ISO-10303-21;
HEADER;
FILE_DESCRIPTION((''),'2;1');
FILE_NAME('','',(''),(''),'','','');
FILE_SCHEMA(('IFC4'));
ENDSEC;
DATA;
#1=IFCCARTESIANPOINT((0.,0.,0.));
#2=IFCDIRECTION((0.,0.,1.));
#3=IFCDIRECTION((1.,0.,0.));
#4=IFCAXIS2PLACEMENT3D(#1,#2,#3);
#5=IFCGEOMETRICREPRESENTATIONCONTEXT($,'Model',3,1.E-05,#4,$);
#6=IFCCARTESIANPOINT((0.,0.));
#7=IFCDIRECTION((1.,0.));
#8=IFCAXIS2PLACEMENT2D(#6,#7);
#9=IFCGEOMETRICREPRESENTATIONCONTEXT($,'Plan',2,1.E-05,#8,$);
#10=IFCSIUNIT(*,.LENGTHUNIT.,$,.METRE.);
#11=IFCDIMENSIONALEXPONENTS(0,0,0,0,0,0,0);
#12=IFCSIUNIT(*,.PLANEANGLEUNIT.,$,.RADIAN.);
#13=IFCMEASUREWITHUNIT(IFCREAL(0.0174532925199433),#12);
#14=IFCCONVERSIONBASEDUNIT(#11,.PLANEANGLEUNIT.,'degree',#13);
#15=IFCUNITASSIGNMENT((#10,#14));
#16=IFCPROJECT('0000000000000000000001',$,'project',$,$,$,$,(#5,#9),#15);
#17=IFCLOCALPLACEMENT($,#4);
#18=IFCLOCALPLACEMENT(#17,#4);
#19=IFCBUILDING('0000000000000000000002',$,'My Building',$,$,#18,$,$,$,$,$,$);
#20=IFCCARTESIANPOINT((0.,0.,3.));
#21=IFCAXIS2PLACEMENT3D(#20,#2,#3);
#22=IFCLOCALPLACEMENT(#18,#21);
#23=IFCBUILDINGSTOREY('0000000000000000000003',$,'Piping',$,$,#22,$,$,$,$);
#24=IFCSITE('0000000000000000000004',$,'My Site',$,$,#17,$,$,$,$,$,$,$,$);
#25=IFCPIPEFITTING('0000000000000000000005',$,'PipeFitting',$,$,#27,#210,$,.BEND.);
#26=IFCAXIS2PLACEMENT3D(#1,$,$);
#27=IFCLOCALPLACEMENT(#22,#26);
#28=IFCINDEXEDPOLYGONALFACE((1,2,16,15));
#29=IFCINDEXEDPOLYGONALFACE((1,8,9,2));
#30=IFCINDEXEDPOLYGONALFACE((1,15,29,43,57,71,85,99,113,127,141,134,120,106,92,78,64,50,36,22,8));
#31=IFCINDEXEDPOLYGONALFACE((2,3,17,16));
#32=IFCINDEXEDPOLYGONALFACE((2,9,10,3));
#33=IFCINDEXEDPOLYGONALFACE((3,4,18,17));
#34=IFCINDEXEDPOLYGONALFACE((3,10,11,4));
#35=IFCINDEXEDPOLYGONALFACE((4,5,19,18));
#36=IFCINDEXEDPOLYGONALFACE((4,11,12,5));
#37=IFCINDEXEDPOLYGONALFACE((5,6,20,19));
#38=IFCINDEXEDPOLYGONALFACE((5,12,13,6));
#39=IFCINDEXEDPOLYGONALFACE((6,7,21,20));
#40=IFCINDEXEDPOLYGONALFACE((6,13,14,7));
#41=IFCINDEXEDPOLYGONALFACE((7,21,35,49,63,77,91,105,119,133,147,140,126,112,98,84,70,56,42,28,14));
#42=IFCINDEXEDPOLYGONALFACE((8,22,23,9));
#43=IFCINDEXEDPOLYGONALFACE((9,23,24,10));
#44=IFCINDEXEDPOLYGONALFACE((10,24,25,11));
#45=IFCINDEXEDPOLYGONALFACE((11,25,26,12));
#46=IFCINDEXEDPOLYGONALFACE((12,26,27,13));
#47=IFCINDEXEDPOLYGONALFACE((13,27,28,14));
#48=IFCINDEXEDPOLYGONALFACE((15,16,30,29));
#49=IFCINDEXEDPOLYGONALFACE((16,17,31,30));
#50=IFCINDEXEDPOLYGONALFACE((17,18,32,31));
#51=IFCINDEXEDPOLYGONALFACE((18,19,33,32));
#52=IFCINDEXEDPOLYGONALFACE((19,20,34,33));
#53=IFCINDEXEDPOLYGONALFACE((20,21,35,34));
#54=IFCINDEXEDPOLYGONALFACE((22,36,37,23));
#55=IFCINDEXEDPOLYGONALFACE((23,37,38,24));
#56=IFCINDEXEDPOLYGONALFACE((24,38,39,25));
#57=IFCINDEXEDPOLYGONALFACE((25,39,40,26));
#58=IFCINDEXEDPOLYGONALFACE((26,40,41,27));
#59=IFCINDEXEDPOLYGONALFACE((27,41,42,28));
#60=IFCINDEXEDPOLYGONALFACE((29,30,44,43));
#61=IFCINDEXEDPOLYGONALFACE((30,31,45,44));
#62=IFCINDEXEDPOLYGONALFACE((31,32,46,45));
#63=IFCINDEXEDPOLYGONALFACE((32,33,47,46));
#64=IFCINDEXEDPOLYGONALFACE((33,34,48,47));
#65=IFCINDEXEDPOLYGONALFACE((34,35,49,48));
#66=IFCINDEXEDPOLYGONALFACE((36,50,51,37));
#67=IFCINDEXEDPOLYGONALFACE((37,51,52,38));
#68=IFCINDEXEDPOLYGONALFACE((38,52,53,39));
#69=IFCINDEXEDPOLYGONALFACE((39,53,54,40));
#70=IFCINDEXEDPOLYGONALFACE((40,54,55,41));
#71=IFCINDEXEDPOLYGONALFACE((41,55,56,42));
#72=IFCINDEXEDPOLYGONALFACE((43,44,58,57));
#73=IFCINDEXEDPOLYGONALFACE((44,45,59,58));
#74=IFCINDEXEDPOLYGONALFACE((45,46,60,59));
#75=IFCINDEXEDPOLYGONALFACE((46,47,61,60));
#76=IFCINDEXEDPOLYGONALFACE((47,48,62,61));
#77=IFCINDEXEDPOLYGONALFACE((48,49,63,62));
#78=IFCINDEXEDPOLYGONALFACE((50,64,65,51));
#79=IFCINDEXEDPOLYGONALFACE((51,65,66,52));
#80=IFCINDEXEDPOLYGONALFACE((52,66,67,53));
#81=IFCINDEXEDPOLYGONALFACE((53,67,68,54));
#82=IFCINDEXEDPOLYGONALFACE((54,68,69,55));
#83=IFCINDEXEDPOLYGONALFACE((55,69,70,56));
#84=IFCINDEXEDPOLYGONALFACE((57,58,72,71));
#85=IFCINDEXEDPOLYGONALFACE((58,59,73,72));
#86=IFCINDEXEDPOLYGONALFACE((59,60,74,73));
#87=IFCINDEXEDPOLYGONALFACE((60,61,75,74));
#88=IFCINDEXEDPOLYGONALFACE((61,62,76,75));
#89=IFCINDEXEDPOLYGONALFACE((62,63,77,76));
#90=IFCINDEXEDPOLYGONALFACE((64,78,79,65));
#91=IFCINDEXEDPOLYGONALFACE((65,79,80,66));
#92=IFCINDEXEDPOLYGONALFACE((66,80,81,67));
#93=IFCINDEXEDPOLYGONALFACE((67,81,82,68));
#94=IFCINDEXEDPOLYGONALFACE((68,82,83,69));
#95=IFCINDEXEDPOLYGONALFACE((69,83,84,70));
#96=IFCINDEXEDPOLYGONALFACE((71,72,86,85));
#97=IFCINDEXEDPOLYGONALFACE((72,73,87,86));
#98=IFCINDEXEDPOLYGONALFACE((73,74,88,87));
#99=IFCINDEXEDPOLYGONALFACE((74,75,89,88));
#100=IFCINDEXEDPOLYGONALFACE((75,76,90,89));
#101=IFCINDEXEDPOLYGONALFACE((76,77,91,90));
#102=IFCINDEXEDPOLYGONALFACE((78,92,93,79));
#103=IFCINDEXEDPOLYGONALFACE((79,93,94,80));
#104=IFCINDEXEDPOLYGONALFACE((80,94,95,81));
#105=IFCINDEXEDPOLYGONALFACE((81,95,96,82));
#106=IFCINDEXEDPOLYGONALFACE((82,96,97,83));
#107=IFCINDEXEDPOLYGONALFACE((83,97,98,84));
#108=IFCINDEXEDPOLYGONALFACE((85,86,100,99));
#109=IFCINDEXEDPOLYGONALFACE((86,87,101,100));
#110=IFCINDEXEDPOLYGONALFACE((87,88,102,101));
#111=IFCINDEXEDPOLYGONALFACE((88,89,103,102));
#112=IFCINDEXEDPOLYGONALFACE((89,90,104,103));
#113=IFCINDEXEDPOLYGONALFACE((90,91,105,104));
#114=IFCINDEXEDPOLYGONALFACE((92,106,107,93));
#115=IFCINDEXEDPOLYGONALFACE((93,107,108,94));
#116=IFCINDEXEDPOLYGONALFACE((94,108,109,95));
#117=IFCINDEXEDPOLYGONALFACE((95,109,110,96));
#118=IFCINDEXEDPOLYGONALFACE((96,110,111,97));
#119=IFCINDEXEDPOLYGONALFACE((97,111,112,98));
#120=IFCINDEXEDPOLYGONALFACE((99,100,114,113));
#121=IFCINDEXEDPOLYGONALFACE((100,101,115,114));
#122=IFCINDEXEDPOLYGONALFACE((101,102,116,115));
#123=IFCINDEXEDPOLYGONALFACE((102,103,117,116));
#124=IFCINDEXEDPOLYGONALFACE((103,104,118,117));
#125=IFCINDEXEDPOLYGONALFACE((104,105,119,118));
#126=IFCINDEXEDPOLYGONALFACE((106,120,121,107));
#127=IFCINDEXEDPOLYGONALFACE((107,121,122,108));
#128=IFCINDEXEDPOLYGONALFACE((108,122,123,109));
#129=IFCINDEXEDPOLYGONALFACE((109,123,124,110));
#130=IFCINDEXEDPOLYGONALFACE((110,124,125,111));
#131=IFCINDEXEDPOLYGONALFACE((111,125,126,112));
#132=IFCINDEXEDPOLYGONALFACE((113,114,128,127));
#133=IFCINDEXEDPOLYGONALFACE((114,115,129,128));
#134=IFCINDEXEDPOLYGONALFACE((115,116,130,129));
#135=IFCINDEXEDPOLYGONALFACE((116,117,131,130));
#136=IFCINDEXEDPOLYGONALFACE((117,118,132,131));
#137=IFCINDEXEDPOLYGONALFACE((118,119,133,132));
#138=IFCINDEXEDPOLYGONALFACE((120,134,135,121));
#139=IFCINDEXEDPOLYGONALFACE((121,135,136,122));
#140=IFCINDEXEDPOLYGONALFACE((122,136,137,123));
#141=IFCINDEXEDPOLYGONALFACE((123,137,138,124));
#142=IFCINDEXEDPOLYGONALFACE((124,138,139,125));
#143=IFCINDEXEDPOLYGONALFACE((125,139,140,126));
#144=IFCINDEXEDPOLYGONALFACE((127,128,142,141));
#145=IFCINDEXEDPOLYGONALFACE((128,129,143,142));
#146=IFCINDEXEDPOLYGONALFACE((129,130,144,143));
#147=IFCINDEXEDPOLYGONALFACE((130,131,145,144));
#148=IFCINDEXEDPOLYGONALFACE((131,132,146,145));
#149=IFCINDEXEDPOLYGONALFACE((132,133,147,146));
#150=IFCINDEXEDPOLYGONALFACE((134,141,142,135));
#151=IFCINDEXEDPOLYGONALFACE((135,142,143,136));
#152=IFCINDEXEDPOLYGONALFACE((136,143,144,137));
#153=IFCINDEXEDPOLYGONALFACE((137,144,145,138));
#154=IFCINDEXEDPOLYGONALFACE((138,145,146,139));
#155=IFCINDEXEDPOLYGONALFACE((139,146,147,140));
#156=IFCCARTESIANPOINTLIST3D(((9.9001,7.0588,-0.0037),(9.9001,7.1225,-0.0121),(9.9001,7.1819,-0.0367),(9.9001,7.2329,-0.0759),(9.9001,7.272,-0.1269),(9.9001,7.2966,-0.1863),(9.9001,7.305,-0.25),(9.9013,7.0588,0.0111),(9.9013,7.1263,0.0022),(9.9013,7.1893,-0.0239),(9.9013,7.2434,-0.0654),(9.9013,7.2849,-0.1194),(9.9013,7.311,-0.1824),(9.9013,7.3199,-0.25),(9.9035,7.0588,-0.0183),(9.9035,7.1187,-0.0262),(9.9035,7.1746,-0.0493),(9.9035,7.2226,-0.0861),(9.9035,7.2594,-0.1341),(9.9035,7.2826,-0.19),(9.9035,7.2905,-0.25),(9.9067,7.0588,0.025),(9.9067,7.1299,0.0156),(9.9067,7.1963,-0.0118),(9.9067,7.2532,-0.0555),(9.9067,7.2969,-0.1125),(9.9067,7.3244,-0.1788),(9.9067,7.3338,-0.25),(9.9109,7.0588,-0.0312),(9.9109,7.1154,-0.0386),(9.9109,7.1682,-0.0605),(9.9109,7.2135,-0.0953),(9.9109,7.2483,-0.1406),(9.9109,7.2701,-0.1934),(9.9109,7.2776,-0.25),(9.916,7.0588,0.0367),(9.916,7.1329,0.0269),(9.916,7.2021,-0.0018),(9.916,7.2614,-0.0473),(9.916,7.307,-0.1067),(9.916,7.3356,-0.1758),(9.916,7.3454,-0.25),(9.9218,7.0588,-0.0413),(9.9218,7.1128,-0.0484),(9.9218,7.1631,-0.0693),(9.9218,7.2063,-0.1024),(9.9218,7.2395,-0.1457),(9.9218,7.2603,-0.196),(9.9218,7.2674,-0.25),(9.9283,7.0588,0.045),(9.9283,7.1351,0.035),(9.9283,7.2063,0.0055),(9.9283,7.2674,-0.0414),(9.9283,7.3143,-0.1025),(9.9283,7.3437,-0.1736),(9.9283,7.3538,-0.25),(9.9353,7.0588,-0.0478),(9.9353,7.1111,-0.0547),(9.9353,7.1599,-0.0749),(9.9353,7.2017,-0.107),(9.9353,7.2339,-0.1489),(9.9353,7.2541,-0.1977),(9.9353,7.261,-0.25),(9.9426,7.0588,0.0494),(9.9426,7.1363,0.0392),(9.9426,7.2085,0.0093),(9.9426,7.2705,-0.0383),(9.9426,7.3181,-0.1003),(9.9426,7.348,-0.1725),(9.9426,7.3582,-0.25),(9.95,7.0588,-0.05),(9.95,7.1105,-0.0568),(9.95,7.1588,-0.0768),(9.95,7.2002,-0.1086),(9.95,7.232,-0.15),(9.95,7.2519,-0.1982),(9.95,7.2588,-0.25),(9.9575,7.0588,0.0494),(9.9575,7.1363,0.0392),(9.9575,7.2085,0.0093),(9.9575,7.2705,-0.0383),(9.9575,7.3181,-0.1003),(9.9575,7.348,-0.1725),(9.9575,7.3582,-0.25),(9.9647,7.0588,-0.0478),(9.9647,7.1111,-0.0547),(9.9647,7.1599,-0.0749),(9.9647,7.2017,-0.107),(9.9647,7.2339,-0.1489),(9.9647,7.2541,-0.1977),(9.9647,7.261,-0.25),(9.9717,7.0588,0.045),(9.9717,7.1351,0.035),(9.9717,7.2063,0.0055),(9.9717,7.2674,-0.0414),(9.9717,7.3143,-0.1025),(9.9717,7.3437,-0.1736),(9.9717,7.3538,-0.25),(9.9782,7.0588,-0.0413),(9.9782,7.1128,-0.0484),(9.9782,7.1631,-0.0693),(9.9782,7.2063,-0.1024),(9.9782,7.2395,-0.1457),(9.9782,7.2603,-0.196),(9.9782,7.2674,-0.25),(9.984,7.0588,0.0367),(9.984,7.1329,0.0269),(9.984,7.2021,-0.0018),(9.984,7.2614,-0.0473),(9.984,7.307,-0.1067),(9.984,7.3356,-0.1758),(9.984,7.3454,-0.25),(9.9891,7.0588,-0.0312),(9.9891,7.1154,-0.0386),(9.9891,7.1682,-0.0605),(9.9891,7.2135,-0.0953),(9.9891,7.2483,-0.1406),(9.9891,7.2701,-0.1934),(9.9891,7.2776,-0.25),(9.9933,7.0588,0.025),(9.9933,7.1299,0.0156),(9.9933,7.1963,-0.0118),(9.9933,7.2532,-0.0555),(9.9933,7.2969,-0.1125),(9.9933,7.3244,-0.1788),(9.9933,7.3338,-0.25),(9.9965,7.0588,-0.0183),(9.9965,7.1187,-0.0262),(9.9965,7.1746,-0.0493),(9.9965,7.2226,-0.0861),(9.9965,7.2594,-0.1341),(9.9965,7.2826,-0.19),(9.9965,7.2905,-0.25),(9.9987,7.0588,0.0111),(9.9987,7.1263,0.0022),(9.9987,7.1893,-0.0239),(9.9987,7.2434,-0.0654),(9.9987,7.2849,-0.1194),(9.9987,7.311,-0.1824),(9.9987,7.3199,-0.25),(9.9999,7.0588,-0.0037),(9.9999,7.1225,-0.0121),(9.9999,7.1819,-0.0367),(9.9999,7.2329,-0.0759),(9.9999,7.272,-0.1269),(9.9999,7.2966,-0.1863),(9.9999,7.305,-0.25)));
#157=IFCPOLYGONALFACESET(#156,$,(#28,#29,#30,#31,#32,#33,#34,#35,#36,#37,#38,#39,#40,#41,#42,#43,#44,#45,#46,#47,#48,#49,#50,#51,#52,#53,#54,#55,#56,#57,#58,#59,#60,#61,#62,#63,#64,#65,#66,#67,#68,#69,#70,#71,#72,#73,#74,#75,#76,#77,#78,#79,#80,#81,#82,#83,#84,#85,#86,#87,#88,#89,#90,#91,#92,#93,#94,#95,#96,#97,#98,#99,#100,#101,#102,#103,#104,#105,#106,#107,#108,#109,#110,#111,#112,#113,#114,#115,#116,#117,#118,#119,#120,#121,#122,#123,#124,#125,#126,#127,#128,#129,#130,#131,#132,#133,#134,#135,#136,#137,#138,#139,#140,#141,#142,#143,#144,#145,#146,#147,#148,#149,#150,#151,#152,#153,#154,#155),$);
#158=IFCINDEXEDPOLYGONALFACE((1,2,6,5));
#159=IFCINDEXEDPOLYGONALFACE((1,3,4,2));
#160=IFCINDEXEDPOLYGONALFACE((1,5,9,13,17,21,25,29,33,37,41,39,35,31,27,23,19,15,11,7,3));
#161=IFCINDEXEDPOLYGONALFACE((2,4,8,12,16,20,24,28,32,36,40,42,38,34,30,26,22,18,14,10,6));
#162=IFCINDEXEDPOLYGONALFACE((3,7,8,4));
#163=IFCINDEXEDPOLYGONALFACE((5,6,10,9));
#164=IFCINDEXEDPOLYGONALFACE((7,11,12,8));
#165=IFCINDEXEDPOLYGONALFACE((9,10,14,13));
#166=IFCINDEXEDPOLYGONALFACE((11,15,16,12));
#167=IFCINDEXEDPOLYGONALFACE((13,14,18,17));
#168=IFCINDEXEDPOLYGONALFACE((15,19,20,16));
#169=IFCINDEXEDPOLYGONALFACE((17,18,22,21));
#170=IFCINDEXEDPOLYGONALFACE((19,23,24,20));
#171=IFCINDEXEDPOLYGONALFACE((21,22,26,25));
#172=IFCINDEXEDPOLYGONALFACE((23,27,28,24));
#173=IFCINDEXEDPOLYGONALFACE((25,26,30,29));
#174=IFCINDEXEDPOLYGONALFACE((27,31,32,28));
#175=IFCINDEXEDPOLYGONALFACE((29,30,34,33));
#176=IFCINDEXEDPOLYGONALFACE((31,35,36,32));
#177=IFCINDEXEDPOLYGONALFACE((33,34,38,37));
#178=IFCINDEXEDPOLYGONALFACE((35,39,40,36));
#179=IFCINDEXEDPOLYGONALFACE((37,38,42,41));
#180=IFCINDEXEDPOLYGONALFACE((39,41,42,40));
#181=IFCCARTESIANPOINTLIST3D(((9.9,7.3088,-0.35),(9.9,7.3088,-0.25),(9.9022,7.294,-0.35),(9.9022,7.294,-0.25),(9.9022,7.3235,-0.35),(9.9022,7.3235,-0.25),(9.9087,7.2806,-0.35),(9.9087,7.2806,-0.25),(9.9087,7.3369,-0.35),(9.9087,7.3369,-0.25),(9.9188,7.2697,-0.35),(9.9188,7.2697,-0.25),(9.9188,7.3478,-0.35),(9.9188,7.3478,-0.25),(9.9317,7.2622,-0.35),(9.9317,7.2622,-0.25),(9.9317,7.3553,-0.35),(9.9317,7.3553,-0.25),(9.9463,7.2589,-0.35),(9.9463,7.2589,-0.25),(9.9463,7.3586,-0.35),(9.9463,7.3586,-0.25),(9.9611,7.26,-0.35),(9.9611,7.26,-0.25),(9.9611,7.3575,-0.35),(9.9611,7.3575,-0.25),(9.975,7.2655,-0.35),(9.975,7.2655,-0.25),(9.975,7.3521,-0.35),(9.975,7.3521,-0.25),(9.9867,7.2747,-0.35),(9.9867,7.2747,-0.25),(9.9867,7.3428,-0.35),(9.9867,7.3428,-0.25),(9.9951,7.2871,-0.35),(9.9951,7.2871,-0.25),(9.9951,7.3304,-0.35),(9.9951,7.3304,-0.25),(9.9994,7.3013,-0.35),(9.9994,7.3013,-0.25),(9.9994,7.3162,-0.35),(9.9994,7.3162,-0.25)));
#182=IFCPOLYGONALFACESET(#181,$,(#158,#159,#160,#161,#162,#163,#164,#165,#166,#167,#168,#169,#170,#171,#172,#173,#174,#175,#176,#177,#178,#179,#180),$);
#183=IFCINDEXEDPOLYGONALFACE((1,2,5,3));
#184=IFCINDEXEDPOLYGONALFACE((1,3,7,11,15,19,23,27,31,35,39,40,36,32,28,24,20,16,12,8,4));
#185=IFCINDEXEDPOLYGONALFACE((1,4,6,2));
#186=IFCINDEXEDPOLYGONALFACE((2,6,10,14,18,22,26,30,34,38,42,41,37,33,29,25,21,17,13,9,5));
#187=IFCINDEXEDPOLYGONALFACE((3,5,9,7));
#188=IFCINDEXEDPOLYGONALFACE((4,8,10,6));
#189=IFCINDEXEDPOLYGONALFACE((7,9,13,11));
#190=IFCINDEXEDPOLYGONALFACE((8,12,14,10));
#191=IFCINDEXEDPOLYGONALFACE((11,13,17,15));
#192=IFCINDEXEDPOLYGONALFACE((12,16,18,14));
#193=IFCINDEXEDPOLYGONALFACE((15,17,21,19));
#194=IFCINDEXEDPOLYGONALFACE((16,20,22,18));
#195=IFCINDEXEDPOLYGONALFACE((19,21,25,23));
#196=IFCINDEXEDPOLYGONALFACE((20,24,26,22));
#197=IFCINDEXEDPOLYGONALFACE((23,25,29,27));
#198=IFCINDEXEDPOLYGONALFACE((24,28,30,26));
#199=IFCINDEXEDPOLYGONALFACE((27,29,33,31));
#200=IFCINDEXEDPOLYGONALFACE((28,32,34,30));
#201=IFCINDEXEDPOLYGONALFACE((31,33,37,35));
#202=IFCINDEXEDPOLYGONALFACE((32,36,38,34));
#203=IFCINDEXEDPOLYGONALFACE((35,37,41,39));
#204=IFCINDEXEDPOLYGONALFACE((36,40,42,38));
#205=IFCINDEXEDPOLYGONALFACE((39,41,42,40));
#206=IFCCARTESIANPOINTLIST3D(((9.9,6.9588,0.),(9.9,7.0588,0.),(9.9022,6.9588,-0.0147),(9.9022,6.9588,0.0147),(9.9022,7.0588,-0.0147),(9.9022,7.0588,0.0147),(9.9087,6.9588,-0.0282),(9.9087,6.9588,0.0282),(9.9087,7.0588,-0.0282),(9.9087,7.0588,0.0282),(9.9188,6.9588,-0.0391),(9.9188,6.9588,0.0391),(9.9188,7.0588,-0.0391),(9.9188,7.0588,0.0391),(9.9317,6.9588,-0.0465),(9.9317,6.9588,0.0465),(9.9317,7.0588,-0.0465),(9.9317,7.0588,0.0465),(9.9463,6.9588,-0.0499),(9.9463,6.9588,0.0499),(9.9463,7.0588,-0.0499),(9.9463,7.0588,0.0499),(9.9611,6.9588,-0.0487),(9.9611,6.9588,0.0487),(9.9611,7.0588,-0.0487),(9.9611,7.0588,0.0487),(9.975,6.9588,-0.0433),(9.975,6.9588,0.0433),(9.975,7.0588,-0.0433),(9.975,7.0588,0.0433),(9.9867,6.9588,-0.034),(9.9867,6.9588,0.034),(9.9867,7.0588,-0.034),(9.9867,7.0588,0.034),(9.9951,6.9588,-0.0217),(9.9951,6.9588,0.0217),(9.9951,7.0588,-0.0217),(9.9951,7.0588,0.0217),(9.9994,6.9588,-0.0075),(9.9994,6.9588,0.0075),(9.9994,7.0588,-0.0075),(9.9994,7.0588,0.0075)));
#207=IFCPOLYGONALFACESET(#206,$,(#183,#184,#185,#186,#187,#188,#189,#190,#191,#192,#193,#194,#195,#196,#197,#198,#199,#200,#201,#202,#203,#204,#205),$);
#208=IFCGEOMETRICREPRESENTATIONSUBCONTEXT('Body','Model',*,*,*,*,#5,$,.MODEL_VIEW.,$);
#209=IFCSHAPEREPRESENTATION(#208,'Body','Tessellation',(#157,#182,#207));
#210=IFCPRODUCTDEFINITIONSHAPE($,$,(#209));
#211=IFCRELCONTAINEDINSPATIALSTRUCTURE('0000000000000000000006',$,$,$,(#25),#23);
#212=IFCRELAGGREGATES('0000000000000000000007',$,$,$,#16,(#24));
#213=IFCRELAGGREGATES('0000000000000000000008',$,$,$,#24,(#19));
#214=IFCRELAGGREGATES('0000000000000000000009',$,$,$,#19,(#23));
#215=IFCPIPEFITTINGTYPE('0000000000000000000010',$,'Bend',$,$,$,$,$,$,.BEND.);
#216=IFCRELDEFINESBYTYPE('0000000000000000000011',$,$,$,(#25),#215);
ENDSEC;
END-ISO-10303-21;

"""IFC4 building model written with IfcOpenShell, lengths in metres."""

from ifc_helpers import new_model, entity, si_unit, converted_unit, frame, origin_with_axes, origin_2d_with_axis, place, context, subcontext, project, spatial, circle, extrude, source, transform, mapped, type_object, type_shapes, element, save


model = new_model("IFC4")

# Units and contexts
model_context = context("Model", 3, precision=1e-05, world=origin_with_axes())
plan_context = context("Plan", 2, precision=1e-05, world=origin_2d_with_axis())
body_context = subcontext(model_context, "Body", "Model", "MODEL_VIEW")
ifc_project = project(units=[si_unit("LENGTHUNIT", "METRE"), converted_unit("PLANEANGLEUNIT", "degree", entity("IfcReal", 0.0174532925199433), si_unit("PLANEANGLEUNIT", "RADIAN"), dimensions=[0, 0, 0, 0, 0, 0, 0])], contexts=[model_context, plan_context])

# Site, building, storey
site_placement = place(None, origin_with_axes())
site = spatial("IfcSite", under=ifc_project, at=site_placement, Name="My Site")
building_placement = place(site_placement, origin_with_axes())
building = spatial("IfcBuilding", under=site, at=building_placement, Name="My Building")
storey_placement = place(building_placement, frame((0.0, 0.0, 3.0), z_axis=(0.0, 0.0, 1.0), x_axis=(1.0, 0.0, 0.0)))
storey = spatial("IfcBuildingStorey", under=building, at=storey_placement, Name="Piping")

# Pipe fitting
pipe_fitting_type = type_object("IfcPipeFittingType", Name="Bend", PredefinedType="BEND")
shared_shape = source(origin_with_axes(), body_context, "Body", "SolidModel", [
    entity("IfcSweptDiskSolid", entity("IfcIndexedPolyCurve", entity("IfcCartesianPointList3D", [[0.0, 0.0, -0.1], [0.0, -0.0732, -0.2768], [0.0, -0.25, -0.35]]), [entity("IfcArcIndex", [1, 2, 3])]), 0.05),
    extrude(circle(Radius=0.05), origin_with_axes(), (0.0, 0.0, -1.0), 0.1),
    extrude(circle(Radius=0.05), frame((0.0, -0.25, -0.35), z_axis=(0.0, -1.0, 0.0), x_axis=(1.0, 0.0, 0.0)), (0.0, 0.0, 1.0), 0.1),
])
type_shapes(pipe_fitting_type, [shared_shape])
for number, where, z_axis, x_axis, name in (
    (1, (9.95, 7.3088, -0.35), (0.0, 0.0, -1.0), (-1.0, 0.0, 0.0), "PipeFitting"),
):
    element("IfcPipeFitting", number, at=place(storey_placement, frame(where, z_axis=z_axis, x_axis=x_axis)), inside=storey, type_object=pipe_fitting_type, Name=name, PredefinedType="BEND", context=body_context, shape_type="MappedRepresentation", body=[
        mapped(shared_shape, transform((0.0, 0.0, 0.0), x_axis=(1.0, 0.0, 0.0), y_axis=(0.0, 1.0, 0.0), z_axis=(0.0, 0.0, 1.0), scale=1.0)),
    ])

save(model, "model.ifc")
